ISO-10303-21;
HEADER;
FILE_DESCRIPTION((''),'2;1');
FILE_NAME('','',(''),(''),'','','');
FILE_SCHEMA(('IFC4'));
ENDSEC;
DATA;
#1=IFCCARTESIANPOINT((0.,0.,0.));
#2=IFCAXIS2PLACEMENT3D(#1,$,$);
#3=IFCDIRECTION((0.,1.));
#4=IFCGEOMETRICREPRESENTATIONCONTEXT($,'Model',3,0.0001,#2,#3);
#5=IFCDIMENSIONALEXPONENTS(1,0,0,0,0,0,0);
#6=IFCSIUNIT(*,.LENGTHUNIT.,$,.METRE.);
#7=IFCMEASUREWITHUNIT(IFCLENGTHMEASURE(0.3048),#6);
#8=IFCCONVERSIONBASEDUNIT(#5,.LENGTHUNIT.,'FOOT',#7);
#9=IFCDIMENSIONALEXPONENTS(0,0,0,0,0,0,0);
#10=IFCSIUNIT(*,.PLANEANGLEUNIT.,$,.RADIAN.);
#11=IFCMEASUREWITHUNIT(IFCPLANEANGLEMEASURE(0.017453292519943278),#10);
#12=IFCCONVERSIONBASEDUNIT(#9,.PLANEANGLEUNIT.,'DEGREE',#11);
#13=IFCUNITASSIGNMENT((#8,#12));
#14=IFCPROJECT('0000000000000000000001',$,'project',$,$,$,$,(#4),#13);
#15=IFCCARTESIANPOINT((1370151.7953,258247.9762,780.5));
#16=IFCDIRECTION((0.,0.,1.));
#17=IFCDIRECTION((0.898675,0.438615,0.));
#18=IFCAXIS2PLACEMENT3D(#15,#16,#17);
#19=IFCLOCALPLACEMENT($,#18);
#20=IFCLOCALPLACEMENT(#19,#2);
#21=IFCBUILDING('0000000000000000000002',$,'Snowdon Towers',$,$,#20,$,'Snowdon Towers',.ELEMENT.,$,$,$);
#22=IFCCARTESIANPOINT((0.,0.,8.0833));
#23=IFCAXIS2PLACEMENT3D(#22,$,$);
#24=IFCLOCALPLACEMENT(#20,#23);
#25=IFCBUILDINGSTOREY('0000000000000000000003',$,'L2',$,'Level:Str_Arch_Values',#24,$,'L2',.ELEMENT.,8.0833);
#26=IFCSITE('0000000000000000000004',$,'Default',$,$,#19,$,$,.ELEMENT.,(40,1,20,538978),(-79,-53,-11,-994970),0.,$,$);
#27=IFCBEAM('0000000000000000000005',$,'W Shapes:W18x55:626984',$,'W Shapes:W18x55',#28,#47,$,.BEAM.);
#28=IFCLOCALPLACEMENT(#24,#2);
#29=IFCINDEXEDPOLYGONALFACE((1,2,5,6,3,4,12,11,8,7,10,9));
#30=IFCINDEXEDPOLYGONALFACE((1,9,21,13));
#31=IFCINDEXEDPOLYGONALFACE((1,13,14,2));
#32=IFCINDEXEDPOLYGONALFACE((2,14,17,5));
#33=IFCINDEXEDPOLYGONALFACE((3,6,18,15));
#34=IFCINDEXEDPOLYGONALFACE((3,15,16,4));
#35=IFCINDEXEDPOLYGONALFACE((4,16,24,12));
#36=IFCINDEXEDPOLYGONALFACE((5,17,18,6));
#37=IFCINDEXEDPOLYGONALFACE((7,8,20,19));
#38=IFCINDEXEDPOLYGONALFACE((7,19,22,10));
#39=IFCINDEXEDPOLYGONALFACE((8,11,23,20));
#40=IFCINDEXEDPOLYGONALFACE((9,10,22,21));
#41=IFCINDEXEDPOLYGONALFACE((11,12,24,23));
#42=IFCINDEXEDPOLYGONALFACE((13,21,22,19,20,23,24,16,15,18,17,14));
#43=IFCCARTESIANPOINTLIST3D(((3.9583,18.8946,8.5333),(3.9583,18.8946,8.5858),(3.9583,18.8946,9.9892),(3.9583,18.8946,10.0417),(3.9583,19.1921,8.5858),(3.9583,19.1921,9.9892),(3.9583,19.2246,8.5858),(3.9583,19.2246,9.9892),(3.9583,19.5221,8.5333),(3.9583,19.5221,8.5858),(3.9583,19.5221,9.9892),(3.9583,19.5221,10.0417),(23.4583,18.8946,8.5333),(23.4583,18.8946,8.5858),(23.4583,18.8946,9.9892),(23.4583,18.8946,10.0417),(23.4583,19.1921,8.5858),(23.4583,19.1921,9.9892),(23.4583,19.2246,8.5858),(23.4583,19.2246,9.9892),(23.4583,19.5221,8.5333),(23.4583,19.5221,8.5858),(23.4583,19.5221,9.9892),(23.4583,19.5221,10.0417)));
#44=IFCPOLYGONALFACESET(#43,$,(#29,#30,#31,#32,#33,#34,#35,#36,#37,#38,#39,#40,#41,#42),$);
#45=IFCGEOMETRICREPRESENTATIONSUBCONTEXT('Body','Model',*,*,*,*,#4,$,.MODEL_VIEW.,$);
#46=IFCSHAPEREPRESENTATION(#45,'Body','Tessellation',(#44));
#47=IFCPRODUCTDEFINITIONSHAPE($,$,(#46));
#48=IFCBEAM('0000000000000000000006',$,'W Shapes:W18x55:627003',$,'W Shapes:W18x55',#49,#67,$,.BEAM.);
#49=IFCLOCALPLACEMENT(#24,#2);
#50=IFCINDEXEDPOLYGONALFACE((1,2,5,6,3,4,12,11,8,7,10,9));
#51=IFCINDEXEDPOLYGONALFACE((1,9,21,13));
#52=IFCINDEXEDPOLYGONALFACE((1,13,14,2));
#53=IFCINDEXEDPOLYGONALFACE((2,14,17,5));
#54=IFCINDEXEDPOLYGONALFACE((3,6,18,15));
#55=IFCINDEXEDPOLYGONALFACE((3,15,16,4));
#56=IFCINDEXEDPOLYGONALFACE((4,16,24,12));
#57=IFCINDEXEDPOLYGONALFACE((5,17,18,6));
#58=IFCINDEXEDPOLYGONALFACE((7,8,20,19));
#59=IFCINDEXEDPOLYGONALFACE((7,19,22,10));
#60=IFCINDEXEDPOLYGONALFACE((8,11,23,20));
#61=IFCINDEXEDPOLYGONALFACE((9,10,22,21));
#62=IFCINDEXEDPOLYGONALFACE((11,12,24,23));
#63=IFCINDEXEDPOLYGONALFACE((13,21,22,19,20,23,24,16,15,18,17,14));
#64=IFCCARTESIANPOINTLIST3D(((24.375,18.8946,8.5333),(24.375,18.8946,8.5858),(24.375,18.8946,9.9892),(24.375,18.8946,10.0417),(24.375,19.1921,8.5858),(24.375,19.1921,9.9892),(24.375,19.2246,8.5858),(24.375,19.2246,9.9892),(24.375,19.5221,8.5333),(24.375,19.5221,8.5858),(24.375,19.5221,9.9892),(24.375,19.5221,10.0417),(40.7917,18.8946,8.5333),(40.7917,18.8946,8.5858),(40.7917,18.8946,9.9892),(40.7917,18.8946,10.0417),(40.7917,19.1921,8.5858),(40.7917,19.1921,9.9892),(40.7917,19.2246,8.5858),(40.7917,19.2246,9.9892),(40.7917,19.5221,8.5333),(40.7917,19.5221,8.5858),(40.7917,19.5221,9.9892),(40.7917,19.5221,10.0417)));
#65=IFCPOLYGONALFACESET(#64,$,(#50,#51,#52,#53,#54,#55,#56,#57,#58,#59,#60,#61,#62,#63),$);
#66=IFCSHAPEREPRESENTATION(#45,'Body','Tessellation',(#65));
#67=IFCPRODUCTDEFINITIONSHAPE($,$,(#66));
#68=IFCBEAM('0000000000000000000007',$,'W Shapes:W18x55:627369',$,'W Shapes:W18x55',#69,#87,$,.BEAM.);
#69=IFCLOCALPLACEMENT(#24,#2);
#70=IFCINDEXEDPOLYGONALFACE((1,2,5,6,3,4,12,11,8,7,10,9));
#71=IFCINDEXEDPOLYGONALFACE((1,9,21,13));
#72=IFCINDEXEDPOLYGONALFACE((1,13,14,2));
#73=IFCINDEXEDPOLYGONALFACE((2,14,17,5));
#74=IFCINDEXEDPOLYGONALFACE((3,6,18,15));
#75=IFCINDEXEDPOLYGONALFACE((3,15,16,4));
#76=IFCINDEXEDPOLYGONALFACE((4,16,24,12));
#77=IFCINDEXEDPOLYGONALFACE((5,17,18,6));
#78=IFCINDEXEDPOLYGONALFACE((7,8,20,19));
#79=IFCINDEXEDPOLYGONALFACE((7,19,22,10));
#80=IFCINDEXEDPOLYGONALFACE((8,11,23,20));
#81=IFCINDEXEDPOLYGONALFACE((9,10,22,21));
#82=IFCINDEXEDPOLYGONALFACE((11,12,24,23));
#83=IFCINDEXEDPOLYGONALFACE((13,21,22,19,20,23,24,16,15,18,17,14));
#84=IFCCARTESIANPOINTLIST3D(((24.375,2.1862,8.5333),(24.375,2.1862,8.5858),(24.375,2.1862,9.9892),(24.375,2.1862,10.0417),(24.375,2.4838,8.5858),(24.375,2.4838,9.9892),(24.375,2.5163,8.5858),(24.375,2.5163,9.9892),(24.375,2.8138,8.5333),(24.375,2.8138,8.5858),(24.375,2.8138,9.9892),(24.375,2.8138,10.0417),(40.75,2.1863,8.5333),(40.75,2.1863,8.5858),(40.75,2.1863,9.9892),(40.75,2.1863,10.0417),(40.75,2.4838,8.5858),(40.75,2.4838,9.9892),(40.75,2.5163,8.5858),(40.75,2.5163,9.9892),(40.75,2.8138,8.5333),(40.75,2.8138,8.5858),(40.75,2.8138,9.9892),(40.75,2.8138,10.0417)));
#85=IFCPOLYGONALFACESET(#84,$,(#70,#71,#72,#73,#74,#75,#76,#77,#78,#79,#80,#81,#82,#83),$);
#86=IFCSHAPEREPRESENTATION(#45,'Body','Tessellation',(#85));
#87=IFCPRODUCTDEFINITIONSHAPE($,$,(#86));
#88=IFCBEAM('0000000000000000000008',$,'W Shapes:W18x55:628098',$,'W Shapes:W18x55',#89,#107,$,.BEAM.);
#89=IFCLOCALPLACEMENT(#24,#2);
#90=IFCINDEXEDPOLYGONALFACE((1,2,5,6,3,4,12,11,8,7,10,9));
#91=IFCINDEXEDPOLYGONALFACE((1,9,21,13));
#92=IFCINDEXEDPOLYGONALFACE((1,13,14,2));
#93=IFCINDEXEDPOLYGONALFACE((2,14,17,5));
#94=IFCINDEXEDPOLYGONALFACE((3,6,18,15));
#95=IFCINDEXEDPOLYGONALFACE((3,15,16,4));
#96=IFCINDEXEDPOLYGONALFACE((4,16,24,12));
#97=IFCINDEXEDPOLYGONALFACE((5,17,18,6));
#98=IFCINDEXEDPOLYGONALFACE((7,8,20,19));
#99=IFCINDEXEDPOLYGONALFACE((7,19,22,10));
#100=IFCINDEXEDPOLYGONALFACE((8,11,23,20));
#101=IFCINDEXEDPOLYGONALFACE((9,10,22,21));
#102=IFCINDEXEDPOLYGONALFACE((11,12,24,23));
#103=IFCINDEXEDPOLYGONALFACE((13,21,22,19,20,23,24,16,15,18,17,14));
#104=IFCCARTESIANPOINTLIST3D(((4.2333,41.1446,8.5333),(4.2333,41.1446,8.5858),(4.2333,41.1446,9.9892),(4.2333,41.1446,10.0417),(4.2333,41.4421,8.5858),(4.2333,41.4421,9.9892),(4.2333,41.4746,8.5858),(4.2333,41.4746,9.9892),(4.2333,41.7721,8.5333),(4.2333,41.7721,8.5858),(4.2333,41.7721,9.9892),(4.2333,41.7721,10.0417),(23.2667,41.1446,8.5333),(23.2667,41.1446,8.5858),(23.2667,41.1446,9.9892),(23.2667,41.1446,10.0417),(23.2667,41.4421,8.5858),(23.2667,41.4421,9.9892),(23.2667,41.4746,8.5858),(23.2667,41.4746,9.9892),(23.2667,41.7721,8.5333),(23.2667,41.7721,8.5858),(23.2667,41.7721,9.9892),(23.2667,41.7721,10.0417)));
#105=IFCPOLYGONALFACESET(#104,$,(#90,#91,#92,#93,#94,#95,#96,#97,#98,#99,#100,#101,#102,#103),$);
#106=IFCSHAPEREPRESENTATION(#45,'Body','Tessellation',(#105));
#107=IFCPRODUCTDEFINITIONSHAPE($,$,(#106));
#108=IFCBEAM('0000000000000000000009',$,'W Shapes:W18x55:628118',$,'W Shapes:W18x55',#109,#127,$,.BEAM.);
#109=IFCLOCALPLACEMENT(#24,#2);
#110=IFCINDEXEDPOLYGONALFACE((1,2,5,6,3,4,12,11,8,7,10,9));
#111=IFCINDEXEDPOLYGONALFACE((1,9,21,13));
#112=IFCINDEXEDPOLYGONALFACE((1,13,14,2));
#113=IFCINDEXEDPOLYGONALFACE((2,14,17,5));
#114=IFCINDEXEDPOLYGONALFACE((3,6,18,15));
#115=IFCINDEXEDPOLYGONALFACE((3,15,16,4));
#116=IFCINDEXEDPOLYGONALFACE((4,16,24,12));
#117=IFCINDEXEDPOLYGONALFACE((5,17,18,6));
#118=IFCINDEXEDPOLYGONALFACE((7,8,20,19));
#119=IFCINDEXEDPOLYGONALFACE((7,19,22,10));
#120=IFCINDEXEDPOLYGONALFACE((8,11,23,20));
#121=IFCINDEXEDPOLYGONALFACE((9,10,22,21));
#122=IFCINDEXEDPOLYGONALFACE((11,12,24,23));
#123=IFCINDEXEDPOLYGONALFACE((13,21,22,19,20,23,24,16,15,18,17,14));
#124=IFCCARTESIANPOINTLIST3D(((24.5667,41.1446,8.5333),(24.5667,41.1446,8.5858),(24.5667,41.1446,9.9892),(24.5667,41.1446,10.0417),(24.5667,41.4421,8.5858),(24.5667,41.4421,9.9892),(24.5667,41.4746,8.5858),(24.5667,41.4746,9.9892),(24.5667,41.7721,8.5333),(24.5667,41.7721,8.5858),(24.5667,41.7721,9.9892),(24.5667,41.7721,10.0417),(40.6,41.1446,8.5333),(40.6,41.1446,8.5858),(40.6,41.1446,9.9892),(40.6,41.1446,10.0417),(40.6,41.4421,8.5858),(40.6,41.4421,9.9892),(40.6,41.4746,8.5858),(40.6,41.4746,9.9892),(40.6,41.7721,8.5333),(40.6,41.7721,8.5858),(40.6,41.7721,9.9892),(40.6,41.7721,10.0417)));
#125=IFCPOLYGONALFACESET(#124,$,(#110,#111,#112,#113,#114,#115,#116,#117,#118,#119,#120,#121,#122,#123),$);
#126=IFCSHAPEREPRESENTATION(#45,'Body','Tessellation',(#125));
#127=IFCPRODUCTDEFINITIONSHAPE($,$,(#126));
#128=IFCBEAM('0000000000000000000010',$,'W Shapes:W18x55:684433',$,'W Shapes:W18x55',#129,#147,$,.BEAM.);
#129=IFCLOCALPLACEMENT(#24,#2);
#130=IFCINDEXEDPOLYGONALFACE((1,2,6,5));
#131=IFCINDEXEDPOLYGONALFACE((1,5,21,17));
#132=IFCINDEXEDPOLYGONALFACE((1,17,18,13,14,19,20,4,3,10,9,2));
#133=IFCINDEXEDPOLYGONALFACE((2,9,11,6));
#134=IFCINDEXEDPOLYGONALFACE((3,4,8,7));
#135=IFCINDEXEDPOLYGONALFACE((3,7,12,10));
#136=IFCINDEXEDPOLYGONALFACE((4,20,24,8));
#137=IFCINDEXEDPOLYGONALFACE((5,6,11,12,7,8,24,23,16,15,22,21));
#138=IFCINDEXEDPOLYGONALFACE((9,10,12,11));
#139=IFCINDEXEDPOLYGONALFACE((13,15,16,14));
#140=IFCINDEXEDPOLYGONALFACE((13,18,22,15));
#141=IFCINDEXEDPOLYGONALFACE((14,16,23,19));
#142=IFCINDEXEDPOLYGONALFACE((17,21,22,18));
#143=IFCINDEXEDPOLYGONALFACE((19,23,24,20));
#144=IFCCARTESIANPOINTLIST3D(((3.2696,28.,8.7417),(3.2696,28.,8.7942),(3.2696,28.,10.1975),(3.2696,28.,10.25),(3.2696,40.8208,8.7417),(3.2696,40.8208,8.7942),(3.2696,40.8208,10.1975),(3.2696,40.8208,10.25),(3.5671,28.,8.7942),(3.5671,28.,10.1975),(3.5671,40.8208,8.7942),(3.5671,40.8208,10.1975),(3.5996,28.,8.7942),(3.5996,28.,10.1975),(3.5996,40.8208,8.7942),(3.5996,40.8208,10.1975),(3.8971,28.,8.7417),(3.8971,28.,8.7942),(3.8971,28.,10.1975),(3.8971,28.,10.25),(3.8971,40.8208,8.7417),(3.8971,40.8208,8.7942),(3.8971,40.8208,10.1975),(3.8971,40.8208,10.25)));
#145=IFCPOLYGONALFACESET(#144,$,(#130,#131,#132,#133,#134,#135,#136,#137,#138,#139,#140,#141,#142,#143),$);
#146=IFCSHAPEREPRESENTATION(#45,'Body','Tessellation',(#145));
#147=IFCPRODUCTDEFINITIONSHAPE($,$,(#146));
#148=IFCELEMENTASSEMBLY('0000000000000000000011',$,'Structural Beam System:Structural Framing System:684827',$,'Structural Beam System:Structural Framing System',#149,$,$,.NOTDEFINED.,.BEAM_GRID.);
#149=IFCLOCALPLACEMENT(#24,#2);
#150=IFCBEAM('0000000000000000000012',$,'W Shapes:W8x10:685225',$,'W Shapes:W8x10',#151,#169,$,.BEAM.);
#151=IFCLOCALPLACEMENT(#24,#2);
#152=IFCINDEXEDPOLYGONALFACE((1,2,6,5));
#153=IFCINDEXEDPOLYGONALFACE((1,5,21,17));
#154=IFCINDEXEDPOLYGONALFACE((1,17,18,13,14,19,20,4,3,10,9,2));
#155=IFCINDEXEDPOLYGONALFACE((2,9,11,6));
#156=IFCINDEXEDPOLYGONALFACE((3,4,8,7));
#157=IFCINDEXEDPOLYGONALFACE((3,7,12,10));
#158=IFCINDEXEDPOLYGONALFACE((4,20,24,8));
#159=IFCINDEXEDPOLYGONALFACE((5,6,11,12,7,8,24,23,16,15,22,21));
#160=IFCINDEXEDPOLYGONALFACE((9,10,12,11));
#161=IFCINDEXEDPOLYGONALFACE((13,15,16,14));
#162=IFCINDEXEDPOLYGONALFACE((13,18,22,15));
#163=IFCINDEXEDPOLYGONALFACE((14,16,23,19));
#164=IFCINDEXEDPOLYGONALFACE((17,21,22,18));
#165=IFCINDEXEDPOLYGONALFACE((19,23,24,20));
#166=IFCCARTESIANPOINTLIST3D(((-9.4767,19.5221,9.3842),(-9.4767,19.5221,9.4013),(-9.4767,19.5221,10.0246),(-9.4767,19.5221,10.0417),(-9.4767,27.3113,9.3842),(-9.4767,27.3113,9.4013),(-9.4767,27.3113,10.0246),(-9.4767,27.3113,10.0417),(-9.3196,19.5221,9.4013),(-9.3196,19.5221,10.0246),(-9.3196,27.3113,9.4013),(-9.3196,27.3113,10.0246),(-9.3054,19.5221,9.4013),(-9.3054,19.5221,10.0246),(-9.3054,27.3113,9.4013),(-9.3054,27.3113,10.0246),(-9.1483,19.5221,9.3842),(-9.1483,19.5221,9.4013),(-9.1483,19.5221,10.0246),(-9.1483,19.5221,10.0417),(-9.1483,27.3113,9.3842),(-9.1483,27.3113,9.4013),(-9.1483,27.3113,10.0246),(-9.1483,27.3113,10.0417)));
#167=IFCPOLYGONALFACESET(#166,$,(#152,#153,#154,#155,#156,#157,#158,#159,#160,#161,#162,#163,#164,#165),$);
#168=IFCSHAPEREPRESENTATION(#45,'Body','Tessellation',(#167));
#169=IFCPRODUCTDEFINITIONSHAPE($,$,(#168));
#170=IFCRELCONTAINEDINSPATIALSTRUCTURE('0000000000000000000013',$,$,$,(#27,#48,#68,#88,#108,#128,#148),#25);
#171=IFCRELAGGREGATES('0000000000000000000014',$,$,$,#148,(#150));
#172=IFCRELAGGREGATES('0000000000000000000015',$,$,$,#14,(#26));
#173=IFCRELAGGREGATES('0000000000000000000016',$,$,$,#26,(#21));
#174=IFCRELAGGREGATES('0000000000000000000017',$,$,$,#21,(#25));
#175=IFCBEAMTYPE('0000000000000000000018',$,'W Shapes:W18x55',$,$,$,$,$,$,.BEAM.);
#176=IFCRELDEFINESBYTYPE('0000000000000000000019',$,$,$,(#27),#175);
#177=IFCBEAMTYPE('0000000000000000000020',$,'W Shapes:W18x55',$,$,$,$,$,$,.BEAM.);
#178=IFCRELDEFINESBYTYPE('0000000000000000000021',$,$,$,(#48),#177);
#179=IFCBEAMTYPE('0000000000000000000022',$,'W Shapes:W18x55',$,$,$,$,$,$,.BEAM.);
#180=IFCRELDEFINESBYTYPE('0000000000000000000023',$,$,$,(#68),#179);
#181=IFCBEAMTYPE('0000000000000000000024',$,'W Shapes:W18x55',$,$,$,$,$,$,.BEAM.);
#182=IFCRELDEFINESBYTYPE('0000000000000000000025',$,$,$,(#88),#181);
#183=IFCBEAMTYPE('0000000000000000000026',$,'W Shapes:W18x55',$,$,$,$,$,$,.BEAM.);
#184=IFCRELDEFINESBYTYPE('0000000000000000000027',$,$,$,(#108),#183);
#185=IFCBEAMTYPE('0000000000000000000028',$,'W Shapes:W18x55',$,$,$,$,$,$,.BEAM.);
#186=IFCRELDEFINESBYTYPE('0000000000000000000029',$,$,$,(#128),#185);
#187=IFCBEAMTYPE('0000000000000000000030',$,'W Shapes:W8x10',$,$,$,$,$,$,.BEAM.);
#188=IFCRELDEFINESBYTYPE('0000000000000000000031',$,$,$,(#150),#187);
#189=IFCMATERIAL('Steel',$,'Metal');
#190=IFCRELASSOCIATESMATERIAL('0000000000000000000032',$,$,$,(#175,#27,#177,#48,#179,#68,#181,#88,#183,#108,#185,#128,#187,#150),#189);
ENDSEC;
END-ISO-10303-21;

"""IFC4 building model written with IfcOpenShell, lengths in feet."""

from ifc_helpers import new_model, entity, si_unit, converted_unit, direction, frame, origin, place, context, subcontext, project, spatial, indexed_curve, outline, extrude, source, transform, mapped, material, type_object, type_shapes, element, aggregate, save


model = new_model("IFC4")

# Units and contexts
model_context = context("Model", 3, precision=0.0001, world=origin(), true_north=direction((0.0, 1.0)))
body_context = subcontext(model_context, "Body", "Model", "MODEL_VIEW")
ifc_project = project(units=[converted_unit("LENGTHUNIT", "FOOT", entity("IfcLengthMeasure", 0.3048), si_unit("LENGTHUNIT", "METRE"), dimensions=[1, 0, 0, 0, 0, 0, 0]), converted_unit("PLANEANGLEUNIT", "DEGREE", entity("IfcPlaneAngleMeasure", 0.017453292519943278), si_unit("PLANEANGLEUNIT", "RADIAN"), dimensions=[0, 0, 0, 0, 0, 0, 0])], contexts=[model_context])

# Site, building, storey
site_placement = place(None, frame((1370151.7953, 258247.9762, 780.5), z_axis=(0.0, 0.0, 1.0), x_axis=(0.898675, 0.438615, 0.0)))
site = spatial("IfcSite", under=ifc_project, at=site_placement, Name="Default", CompositionType="ELEMENT", RefLatitude=(40, 1, 20, 538978), RefLongitude=(-79, -53, -11, -994970), RefElevation=0.0)
building_placement = place(site_placement, origin())
building = spatial("IfcBuilding", under=site, at=building_placement, Name="Snowdon Towers", LongName="Snowdon Towers", CompositionType="ELEMENT")
storey_placement = place(building_placement, frame((0.0, 0.0, 8.0833)))
storey = spatial("IfcBuildingStorey", under=building, at=storey_placement, Name="L2", ObjectType="Level:Str_Arch_Values", LongName="L2", CompositionType="ELEMENT", Elevation=8.0833)

# Shared definitions
ifc_material = material(Name="Steel", Category="Metal")

# Beams
beam_type_1 = type_object("IfcBeamType", Name="W Shapes:W18x55", PredefinedType="BEAM", material=ifc_material)
shared_shape_1 = source(origin(), body_context, "Body", "SweptSolid", [
    extrude(outline(indexed_curve([(-0.3138, -0.7017), (-0.3138, -0.7542), (0.3138, -0.7542), (0.3138, -0.7017), (0.0162, -0.7017), (0.0162, 0.7017), (0.3138, 0.7017), (0.3138, 0.7542), (-0.3137, 0.7542), (-0.3137, 0.7017), (-0.0163, 0.7017), (-0.0163, -0.7017), (-0.3138, -0.7017)], self_intersect=False)), frame((-9.75, 0.0, 0.0), z_axis=(-1.0, 0.0, 0.0), x_axis=(0.0, -1.0, 0.0)), (0.0, 0.0, -1.0), 19.5),
])
type_shapes(beam_type_1, [shared_shape_1])
beam_1_placement = place(storey_placement, frame((13.7083, 19.2083, 9.2875)))
element("IfcBeam", 1, at=beam_1_placement, inside=storey, type_object=beam_type_1, material=ifc_material, Name="W Shapes:W18x55:626984", ObjectType="W Shapes:W18x55", PredefinedType="BEAM", context=body_context, shape_type="MappedRepresentation", body=[
    mapped(shared_shape_1, transform((0.0, 0.0, 0.0), scale=1.0)),
])
beam_type_2 = type_object("IfcBeamType", Name="W Shapes:W18x55", PredefinedType="BEAM", material=ifc_material)
shared_shape_2 = source(origin(), body_context, "Body", "SweptSolid", [
    extrude(outline(indexed_curve([(-0.3138, -0.7017), (-0.3138, -0.7542), (0.3138, -0.7542), (0.3138, -0.7017), (0.0162, -0.7017), (0.0162, 0.7017), (0.3138, 0.7017), (0.3138, 0.7542), (-0.3137, 0.7542), (-0.3137, 0.7017), (-0.0163, 0.7017), (-0.0163, -0.7017), (-0.3138, -0.7017)], self_intersect=False)), frame((-8.2083, 0.0, 0.0), z_axis=(-1.0, 0.0, 0.0), x_axis=(0.0, -1.0, 0.0)), (0.0, 0.0, -1.0), 16.4167),
])
type_shapes(beam_type_2, [shared_shape_2])
beam_2_placement = place(storey_placement, frame((32.5833, 19.2083, 9.2875)))
element("IfcBeam", 2, at=beam_2_placement, inside=storey, type_object=beam_type_2, material=ifc_material, Name="W Shapes:W18x55:627003", ObjectType="W Shapes:W18x55", PredefinedType="BEAM", context=body_context, shape_type="MappedRepresentation", body=[
    mapped(shared_shape_2, transform((0.0, 0.0, 0.0), scale=1.0)),
])
beam_type_3 = type_object("IfcBeamType", Name="W Shapes:W18x55", PredefinedType="BEAM", material=ifc_material)
shared_shape_3 = source(origin(), body_context, "Body", "SweptSolid", [
    extrude(outline(indexed_curve([(-0.3138, -0.7017), (-0.3138, -0.7542), (0.3138, -0.7542), (0.3138, -0.7017), (0.0162, -0.7017), (0.0162, 0.7017), (0.3138, 0.7017), (0.3138, 0.7542), (-0.3137, 0.7542), (-0.3137, 0.7017), (-0.0163, 0.7017), (-0.0163, -0.7017), (-0.3138, -0.7017)], self_intersect=False)), frame((-7.9583, 0.0, 0.0), z_axis=(-1.0, 0.0, 0.0), x_axis=(0.0, -1.0, 0.0)), (0.0, 0.0, -1.0), 16.375),
])
type_shapes(beam_type_3, [shared_shape_3])
beam_3_placement = place(storey_placement, frame((32.3333, 2.5, 9.2875)))
element("IfcBeam", 3, at=beam_3_placement, inside=storey, type_object=beam_type_3, material=ifc_material, Name="W Shapes:W18x55:627369", ObjectType="W Shapes:W18x55", PredefinedType="BEAM", context=body_context, shape_type="MappedRepresentation", body=[
    mapped(shared_shape_3, transform((0.0, 0.0, 0.0), scale=1.0)),
])
beam_type_4 = type_object("IfcBeamType", Name="W Shapes:W18x55", PredefinedType="BEAM", material=ifc_material)
shared_shape_4 = source(origin(), body_context, "Body", "SweptSolid", [
    extrude(outline(indexed_curve([(-0.3138, -0.7017), (-0.3138, -0.7542), (0.3138, -0.7542), (0.3138, -0.7017), (0.0162, -0.7017), (0.0162, 0.7017), (0.3138, 0.7017), (0.3138, 0.7542), (-0.3137, 0.7542), (-0.3137, 0.7017), (-0.0163, 0.7017), (-0.0163, -0.7017), (-0.3138, -0.7017)], self_intersect=False)), frame((-9.6, 0.0, 0.0), z_axis=(-1.0, 0.0, 0.0), x_axis=(0.0, -1.0, 0.0)), (0.0, 0.0, -1.0), 19.0333),
])
type_shapes(beam_type_4, [shared_shape_4])
beam_4_placement = place(storey_placement, frame((13.8333, 41.4583, 9.2875)))
element("IfcBeam", 4, at=beam_4_placement, inside=storey, type_object=beam_type_4, material=ifc_material, Name="W Shapes:W18x55:628098", ObjectType="W Shapes:W18x55", PredefinedType="BEAM", context=body_context, shape_type="MappedRepresentation", body=[
    mapped(shared_shape_4, transform((0.0, 0.0, 0.0), scale=1.0)),
])
beam_type_5 = type_object("IfcBeamType", Name="W Shapes:W18x55", PredefinedType="BEAM", material=ifc_material)
shared_shape_5 = source(origin(), body_context, "Body", "SweptSolid", [
    extrude(outline(indexed_curve([(-0.3138, -0.7017), (-0.3138, -0.7542), (0.3138, -0.7542), (0.3138, -0.7017), (0.0162, -0.7017), (0.0162, 0.7017), (0.3138, 0.7017), (0.3138, 0.7542), (-0.3137, 0.7542), (-0.3137, 0.7017), (-0.0163, 0.7017), (-0.0163, -0.7017), (-0.3138, -0.7017)], self_intersect=False)), frame((-8.0167, 0.0, 0.0), z_axis=(-1.0, 0.0, 0.0), x_axis=(0.0, -1.0, 0.0)), (0.0, 0.0, -1.0), 16.0333),
])
type_shapes(beam_type_5, [shared_shape_5])
beam_5_placement = place(storey_placement, frame((32.5833, 41.4583, 9.2875)))
element("IfcBeam", 5, at=beam_5_placement, inside=storey, type_object=beam_type_5, material=ifc_material, Name="W Shapes:W18x55:628118", ObjectType="W Shapes:W18x55", PredefinedType="BEAM", context=body_context, shape_type="MappedRepresentation", body=[
    mapped(shared_shape_5, transform((0.0, 0.0, 0.0), scale=1.0)),
])
beam_type_6 = type_object("IfcBeamType", Name="W Shapes:W18x55", PredefinedType="BEAM", material=ifc_material)
shared_shape_6 = source(origin(), body_context, "Body", "SweptSolid", [
    extrude(outline(indexed_curve([(-0.3138, -0.7017), (-0.3138, -0.7542), (0.3138, -0.7542), (0.3138, -0.7017), (0.0162, -0.7017), (0.0162, 0.7017), (0.3138, 0.7017), (0.3138, 0.7542), (-0.3137, 0.7542), (-0.3137, 0.7017), (-0.0163, 0.7017), (-0.0163, -0.7017), (-0.3138, -0.7017)], self_intersect=False)), frame((-6.2375, 0.0, 0.0), z_axis=(-1.0, 0.0, 0.0), x_axis=(0.0, -1.0, 0.0)), (0.0, 0.0, -1.0), 12.8208),
])
type_shapes(beam_type_6, [shared_shape_6])
beam_6_placement = place(storey_placement, frame((3.5833, 34.5833, 9.4958), z_axis=(0.0, 0.0, 1.0), x_axis=(0.0, -1.0, 0.0)))
element("IfcBeam", 6, at=beam_6_placement, inside=storey, type_object=beam_type_6, material=ifc_material, Name="W Shapes:W18x55:684433", ObjectType="W Shapes:W18x55", PredefinedType="BEAM", context=body_context, shape_type="MappedRepresentation", body=[
    mapped(shared_shape_6, transform((0.0, 0.0, 0.0), scale=1.0)),
])

# Element assembly, beam
assembly_1_placement = place(storey_placement, origin())
assembly_1 = element("IfcElementAssembly", 7, at=assembly_1_placement, inside=storey, Name="Structural Beam System:Structural Framing System:684827", ObjectType="Structural Beam System:Structural Framing System", AssemblyPlace="NOTDEFINED", PredefinedType="BEAM_GRID")
beam_type_7 = type_object("IfcBeamType", Name="W Shapes:W8x10", PredefinedType="BEAM", material=ifc_material)
shared_shape_7 = source(origin(), body_context, "Body", "SweptSolid", [
    extrude(outline(indexed_curve([(-0.1642, -0.3117), (-0.1642, -0.3288), (0.1642, -0.3288), (0.1642, -0.3117), (0.0071, -0.3117), (0.0071, 0.3117), (0.1642, 0.3117), (0.1642, 0.3287), (-0.1642, 0.3287), (-0.1642, 0.3117), (-0.0071, 0.3117), (-0.0071, -0.3117), (-0.1642, -0.3117)], self_intersect=False)), frame((-3.8946, 0.0, 0.0), z_axis=(-1.0, 0.0, 0.0), x_axis=(0.0, -1.0, 0.0)), (0.0, 0.0, -1.0), 7.7892),
])
type_shapes(beam_type_7, [shared_shape_7])
beam_7_placement = place(assembly_1_placement, frame((-9.3125, 23.4167, 9.7129), z_axis=(0.0, 0.0, 1.0), x_axis=(0.0, 1.0, 0.0)))
beam_7 = element("IfcBeam", 8, at=beam_7_placement, type_object=beam_type_7, material=ifc_material, Name="W Shapes:W8x10:685225", ObjectType="W Shapes:W8x10", PredefinedType="BEAM", context=body_context, shape_type="MappedRepresentation", body=[
    mapped(shared_shape_7, transform((0.0, 0.0, 0.0), scale=1.0)),
])
aggregate(assembly_1, [beam_7])

save(model, "model.ifc")
